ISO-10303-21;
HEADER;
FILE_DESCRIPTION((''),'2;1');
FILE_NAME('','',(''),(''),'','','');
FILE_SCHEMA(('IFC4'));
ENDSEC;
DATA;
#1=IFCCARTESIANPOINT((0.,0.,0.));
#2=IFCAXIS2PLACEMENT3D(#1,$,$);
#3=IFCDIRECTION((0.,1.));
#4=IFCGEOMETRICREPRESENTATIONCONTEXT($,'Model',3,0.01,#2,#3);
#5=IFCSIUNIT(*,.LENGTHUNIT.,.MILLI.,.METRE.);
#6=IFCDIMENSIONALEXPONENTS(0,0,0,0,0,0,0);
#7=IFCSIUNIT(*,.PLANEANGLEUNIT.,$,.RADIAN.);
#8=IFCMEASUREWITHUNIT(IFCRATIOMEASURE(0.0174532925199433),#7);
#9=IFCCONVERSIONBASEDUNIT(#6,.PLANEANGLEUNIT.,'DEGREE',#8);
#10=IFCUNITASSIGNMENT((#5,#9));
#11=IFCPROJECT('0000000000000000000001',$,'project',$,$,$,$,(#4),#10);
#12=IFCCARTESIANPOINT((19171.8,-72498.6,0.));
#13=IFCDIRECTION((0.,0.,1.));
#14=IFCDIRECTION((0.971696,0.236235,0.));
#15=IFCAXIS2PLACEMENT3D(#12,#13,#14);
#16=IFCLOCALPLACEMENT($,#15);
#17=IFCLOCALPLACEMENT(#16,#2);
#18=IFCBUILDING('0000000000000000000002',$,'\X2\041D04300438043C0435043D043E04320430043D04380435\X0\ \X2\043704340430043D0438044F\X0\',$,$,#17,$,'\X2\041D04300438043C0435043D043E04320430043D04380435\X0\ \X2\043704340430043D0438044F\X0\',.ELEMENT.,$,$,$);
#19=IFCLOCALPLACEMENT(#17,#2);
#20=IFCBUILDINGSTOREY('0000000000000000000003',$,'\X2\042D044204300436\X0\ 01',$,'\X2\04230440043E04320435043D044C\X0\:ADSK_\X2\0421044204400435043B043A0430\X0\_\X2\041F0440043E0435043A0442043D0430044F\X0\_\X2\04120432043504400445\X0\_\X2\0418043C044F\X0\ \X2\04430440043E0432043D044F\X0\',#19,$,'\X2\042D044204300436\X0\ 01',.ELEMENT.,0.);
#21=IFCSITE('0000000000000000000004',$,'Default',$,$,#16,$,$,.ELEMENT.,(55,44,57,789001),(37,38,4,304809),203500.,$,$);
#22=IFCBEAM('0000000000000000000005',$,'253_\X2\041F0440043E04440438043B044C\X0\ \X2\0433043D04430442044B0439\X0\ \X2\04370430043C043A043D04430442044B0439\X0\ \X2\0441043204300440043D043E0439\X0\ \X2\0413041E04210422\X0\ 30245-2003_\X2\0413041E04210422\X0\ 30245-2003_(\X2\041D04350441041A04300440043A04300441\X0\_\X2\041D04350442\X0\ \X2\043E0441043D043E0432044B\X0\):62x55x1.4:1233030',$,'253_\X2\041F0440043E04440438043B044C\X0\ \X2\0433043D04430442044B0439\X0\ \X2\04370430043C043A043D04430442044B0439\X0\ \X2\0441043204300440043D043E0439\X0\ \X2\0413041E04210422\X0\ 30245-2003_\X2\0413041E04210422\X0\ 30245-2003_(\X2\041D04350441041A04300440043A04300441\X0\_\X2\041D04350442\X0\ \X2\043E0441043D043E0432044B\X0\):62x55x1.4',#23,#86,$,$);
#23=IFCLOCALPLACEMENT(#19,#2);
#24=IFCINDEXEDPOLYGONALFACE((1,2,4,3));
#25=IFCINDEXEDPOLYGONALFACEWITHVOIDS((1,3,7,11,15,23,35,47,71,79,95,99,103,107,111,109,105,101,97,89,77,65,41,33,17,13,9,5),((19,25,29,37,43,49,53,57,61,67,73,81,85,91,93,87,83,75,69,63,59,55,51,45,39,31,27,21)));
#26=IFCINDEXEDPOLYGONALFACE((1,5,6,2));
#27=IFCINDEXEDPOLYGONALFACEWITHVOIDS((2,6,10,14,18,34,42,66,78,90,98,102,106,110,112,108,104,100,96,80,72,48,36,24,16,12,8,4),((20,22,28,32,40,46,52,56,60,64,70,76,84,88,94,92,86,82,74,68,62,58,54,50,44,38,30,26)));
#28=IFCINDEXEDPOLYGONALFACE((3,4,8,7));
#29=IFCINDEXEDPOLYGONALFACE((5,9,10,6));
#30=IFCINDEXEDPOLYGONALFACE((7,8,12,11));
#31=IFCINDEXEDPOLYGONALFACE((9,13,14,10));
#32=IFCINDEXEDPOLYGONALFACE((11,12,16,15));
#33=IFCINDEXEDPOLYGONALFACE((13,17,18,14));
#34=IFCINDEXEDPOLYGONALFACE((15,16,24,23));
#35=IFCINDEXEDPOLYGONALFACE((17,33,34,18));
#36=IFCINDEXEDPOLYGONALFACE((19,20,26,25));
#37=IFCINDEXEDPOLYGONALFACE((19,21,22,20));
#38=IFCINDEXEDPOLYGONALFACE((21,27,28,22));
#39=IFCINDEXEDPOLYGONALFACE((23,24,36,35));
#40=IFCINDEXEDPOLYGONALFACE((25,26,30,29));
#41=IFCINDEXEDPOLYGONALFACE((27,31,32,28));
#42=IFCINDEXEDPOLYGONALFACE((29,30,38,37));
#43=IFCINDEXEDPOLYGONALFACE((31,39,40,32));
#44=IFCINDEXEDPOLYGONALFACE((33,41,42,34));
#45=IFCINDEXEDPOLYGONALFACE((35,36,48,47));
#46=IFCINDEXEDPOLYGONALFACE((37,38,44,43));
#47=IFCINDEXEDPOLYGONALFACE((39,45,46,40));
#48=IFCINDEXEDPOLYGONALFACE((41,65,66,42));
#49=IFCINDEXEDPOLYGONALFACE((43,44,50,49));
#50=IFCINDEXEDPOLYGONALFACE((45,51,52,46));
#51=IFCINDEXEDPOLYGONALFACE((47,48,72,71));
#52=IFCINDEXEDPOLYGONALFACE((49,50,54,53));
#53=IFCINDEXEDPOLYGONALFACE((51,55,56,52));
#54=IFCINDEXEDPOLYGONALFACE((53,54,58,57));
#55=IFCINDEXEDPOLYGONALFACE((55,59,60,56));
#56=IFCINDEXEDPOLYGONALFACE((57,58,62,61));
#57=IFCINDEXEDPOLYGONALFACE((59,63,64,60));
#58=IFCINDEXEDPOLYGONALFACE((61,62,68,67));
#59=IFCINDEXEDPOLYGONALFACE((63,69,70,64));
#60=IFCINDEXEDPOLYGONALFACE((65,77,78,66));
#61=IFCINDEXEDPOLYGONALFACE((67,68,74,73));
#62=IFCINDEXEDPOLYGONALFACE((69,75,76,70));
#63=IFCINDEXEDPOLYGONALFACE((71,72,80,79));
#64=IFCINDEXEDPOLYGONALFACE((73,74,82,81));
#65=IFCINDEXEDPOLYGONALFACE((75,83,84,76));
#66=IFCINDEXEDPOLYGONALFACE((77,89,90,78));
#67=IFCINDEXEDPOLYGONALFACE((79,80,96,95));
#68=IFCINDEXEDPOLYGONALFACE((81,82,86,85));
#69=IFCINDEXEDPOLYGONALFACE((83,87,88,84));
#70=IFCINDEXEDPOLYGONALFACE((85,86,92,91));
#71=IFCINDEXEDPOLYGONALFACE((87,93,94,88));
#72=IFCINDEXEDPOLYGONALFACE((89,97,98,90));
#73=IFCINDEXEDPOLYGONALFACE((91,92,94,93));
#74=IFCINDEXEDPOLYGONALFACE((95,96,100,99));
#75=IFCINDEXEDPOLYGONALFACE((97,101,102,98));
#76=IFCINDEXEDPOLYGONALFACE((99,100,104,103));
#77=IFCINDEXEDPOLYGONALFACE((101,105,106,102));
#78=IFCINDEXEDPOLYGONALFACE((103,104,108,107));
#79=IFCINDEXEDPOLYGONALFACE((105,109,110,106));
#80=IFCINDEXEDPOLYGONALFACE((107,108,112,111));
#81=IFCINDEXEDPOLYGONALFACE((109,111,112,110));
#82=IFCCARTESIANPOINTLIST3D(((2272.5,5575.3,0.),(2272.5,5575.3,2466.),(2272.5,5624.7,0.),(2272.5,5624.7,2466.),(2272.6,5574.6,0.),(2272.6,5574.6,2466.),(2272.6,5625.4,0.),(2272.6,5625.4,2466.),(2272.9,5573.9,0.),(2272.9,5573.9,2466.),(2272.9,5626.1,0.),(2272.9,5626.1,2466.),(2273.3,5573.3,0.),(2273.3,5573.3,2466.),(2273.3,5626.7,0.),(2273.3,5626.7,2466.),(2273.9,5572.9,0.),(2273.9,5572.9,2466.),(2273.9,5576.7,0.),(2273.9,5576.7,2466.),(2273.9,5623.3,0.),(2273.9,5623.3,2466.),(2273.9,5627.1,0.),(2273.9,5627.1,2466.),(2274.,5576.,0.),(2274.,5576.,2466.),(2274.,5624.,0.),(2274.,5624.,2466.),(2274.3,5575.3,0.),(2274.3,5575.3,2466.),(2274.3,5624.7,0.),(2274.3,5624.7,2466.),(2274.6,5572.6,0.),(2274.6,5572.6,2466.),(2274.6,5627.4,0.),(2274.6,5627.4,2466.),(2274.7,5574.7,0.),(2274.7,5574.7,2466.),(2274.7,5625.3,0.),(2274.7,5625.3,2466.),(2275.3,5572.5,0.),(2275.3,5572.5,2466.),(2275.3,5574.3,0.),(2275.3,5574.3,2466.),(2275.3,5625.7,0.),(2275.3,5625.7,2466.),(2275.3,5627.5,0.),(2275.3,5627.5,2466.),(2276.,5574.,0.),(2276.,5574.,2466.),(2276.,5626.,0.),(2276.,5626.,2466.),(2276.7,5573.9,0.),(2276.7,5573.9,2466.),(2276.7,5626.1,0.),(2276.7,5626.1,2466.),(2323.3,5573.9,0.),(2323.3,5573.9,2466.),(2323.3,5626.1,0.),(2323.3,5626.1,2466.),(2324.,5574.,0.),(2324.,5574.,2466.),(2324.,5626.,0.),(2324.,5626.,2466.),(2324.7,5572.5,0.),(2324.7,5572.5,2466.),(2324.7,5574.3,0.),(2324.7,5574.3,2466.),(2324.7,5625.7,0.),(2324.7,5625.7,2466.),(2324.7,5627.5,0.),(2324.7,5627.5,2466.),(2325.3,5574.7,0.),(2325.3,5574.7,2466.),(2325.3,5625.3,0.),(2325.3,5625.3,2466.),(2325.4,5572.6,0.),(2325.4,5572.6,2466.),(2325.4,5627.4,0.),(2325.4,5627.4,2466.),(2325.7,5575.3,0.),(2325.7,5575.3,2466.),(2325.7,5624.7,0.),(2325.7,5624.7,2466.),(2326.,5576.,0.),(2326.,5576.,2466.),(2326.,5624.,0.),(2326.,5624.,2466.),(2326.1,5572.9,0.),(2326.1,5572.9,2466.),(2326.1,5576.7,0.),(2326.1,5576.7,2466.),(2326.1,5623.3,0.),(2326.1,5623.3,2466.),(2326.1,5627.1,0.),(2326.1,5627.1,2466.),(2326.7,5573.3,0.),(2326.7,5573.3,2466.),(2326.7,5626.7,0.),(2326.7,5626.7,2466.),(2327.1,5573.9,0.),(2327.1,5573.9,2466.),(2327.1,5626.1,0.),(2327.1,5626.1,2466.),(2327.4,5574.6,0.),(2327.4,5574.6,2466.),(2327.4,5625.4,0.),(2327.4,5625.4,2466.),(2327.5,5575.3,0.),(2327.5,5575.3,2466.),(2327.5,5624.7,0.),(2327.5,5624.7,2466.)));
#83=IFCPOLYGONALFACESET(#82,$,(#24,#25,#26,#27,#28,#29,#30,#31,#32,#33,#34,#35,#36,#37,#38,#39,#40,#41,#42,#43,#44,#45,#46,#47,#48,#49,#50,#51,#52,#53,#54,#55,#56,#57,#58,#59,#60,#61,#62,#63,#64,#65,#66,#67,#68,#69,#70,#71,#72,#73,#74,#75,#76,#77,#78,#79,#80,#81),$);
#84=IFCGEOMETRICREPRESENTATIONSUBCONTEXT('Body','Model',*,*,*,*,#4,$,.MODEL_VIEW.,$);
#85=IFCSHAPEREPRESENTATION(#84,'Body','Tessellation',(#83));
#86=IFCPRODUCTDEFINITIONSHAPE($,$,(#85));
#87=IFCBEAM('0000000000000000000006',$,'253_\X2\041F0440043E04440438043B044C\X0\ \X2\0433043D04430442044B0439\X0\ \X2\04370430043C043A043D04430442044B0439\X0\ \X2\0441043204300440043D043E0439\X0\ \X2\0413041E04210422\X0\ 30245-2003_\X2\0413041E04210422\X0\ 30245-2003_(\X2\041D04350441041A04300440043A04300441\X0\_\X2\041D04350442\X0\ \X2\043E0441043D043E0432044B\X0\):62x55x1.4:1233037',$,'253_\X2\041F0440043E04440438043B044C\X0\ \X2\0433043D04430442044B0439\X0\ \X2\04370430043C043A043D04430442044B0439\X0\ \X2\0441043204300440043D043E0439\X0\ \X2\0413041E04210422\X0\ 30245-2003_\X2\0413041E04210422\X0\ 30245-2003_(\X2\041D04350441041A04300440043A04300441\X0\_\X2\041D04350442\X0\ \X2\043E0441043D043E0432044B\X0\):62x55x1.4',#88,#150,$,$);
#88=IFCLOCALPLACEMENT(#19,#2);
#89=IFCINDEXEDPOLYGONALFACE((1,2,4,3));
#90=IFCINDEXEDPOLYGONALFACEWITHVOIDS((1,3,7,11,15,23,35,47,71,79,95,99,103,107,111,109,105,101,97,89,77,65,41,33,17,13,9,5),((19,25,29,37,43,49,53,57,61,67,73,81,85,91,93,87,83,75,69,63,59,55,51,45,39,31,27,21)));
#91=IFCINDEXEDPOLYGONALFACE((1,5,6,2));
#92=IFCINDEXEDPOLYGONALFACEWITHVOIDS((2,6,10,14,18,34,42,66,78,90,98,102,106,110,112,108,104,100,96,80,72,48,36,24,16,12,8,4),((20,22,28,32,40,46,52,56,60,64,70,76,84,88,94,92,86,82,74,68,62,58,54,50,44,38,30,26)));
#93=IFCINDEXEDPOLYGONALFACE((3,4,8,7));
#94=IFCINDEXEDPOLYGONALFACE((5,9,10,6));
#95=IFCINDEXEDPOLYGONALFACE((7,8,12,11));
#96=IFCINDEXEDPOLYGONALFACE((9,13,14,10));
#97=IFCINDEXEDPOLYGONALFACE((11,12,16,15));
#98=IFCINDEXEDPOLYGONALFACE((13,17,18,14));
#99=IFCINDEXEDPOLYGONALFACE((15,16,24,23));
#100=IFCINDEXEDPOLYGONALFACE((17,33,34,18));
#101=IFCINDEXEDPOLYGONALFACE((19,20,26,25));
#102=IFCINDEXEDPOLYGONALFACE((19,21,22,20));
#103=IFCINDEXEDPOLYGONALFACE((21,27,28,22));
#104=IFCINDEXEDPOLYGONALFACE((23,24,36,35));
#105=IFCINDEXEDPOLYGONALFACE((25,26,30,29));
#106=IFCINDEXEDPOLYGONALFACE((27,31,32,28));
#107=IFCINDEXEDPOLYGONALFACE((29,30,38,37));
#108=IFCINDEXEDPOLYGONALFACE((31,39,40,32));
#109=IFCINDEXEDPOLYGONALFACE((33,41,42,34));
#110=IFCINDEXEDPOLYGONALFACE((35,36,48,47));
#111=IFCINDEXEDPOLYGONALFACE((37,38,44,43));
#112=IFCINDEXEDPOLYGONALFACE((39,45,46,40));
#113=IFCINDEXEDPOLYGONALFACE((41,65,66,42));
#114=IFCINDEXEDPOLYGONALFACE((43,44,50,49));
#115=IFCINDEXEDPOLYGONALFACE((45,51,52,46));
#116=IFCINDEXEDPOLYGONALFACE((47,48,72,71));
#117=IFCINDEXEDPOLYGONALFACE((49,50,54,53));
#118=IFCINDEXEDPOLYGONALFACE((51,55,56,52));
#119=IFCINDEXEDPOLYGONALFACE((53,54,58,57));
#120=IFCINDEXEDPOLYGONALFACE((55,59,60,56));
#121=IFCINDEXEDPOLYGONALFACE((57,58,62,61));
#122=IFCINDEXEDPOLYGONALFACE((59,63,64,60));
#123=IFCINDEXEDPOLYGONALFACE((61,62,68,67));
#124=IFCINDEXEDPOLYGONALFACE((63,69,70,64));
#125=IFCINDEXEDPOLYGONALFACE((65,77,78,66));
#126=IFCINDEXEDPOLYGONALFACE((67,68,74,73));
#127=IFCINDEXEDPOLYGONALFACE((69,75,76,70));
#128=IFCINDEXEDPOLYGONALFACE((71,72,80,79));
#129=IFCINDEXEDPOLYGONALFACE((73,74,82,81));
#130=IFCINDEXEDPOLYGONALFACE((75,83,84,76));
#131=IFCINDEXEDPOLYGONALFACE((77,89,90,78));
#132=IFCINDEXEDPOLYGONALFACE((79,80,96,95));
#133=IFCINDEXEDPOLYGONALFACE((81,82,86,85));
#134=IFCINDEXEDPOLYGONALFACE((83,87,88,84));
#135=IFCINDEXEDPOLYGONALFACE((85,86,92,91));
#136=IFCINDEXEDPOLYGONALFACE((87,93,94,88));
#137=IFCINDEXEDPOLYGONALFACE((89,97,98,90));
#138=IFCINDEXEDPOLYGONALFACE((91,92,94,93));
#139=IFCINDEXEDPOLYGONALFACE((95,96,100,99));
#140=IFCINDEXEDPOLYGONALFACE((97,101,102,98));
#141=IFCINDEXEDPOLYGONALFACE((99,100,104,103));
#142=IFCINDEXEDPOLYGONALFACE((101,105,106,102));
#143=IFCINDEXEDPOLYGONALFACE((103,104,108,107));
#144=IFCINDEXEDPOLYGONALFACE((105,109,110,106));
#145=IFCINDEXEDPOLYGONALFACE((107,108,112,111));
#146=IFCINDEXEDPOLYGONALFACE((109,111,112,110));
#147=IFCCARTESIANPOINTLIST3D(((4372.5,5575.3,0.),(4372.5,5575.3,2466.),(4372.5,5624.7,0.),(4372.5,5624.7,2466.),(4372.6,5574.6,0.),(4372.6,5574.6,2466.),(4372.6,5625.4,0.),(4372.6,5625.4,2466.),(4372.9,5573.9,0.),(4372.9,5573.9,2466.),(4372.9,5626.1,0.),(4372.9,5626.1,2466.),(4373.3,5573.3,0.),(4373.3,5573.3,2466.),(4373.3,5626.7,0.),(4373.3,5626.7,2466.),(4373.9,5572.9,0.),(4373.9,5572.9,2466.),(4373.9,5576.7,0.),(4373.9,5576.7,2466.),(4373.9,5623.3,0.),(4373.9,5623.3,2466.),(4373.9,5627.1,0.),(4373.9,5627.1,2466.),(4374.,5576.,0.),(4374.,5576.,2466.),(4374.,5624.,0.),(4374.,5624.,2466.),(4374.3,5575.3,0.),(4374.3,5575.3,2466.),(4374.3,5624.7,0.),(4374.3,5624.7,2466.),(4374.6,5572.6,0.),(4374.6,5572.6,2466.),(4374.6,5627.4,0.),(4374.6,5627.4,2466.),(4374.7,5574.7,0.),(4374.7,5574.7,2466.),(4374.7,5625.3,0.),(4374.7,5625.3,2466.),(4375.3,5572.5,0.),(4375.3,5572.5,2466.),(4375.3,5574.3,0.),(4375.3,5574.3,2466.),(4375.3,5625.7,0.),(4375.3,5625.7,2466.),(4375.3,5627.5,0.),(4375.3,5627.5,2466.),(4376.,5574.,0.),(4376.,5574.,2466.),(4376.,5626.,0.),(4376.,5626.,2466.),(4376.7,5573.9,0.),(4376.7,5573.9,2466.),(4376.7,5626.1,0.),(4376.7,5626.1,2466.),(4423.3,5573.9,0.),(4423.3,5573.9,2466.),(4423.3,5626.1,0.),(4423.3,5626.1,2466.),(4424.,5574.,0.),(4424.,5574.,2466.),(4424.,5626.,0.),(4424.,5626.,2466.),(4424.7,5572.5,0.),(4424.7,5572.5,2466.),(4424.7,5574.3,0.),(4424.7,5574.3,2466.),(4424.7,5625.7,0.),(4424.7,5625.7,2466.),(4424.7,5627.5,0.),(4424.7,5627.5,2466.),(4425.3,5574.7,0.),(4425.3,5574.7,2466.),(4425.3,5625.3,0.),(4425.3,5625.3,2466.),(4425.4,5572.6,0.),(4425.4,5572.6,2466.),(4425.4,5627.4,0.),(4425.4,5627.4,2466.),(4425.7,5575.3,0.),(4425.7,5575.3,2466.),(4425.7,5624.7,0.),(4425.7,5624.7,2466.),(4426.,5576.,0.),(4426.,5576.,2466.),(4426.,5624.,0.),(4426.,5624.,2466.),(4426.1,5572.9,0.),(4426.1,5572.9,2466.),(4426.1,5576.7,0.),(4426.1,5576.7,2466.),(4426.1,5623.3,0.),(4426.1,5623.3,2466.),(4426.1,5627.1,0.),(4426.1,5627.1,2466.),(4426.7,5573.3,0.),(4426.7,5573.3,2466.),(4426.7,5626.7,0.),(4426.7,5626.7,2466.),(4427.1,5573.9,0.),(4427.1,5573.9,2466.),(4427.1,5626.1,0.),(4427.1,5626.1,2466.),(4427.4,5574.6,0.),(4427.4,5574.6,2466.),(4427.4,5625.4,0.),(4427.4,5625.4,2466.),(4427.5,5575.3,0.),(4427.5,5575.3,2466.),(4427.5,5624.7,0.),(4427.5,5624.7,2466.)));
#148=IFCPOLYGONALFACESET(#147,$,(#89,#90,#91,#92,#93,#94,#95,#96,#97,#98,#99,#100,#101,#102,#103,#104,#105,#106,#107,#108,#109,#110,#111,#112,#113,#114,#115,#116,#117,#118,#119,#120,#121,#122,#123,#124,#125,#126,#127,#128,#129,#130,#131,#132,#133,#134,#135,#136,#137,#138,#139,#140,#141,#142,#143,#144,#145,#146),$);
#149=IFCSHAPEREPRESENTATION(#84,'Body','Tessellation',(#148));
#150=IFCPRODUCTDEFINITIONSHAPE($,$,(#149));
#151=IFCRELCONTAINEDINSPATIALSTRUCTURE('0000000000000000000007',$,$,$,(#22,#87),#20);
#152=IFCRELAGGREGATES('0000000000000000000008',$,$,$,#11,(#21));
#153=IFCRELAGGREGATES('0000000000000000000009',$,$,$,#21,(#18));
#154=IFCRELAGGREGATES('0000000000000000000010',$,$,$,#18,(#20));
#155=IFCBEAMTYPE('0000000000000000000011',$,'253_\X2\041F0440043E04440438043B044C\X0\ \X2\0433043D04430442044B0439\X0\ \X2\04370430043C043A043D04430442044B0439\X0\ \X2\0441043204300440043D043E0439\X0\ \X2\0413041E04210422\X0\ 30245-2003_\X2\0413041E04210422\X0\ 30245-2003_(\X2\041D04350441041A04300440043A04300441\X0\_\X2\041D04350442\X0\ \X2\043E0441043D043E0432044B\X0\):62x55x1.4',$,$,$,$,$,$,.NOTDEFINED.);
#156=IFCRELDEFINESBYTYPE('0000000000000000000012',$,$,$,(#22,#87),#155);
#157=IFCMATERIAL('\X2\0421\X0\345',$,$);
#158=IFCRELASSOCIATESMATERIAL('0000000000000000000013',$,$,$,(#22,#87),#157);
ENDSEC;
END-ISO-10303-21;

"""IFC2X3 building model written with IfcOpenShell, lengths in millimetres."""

from ifc_helpers import new_model, entity, si_unit, converted_unit, direction, frame, frame_2d, origin, place, context, subcontext, project, spatial, polyline, circle_curve, parameter, trimmed, segment, composite_curve, outline, extrude, material, type_object, element, save


model = new_model("IFC2X3")

# Units and contexts
model_context = context("Model", 3, precision=0.01, world=origin(), true_north=direction((0.0, 1.0)))
body_context = subcontext(model_context, "Body", "Model", "MODEL_VIEW")
ifc_project = project(units=[si_unit("LENGTHUNIT", "METRE", prefix="MILLI"), converted_unit("PLANEANGLEUNIT", "DEGREE", entity("IfcRatioMeasure", 0.0174532925199433), si_unit("PLANEANGLEUNIT", "RADIAN"), dimensions=[0, 0, 0, 0, 0, 0, 0])], contexts=[model_context])

# Site, building, storey
site_placement = place(None, frame((19171.8, -72498.6, 0.0), z_axis=(0.0, 0.0, 1.0), x_axis=(0.971696, 0.236235, 0.0)))
site = spatial("IfcSite", under=ifc_project, at=site_placement, Name="Default", CompositionType="ELEMENT", RefLatitude=(55, 44, 57, 789001), RefLongitude=(37, 38, 4, 304809), RefElevation=203500.0)
building_placement = place(site_placement, origin())
building = spatial("IfcBuilding", under=site, at=building_placement, Name="Наименование здания", LongName="Наименование здания", CompositionType="ELEMENT")
storey_placement = place(building_placement, origin())
storey = spatial("IfcBuildingStorey", under=building, at=storey_placement, Name="Этаж 01", ObjectType="Уровень:ADSK_Стрелка_Проектная_Вверх_Имя уровня", LongName="Этаж 01", CompositionType="ELEMENT", Elevation=0.0)

# Beams
ifc_material_1 = material(Name="С345")
beam_type_1 = type_object("IfcBeamType", Name="253_Профиль гнутый замкнутый сварной ГОСТ 30245-2003_ГОСТ 30245-2003_(НесКаркас_Нет основы):62x55x1.4", PredefinedType="NOTDEFINED")
beam_1_placement = place(storey_placement, frame((2270.9, 5570.9, 0.0), z_axis=(1.0, 0.0, 0.0), x_axis=(0.0, 0.0, -1.0)))
element("IfcBeam", 1, at=beam_1_placement, inside=storey, type_object=beam_type_1, material=ifc_material_1, Name="253_Профиль гнутый замкнутый сварной ГОСТ 30245-2003_ГОСТ 30245-2003_(НесКаркас_Нет основы):62x55x1.4:1233030", ObjectType="253_Профиль гнутый замкнутый сварной ГОСТ 30245-2003_ГОСТ 30245-2003_(НесКаркас_Нет основы):62x55x1.4", context=body_context, shape_type="SweptSolid", body=[
    extrude(outline(composite_curve([segment(trimmed(circle_curve(frame_2d((24.7, -24.7), x_axis=(1.0, 0.0)), 2.8), [parameter(270.0)], [parameter(0.0)], True, "PARAMETER"), True, "CONTINUOUS"), segment(polyline([(27.5, -24.7), (27.5, 24.7)]), True, "CONTINUOUS"), segment(trimmed(circle_curve(frame_2d((24.7, 24.7), x_axis=(1.0, 0.0)), 2.8), [parameter(0.0)], [parameter(90.0)], True, "PARAMETER"), True, "CONTINUOUS"), segment(polyline([(24.7, 27.5), (-24.7, 27.5)]), True, "CONTINUOUS"), segment(trimmed(circle_curve(frame_2d((-24.7, 24.7), x_axis=(1.0, 0.0)), 2.8), [parameter(90.0)], [parameter(180.0)], True, "PARAMETER"), True, "CONTINUOUS"), segment(polyline([(-27.5, 24.7), (-27.5, -24.7)]), True, "CONTINUOUS"), segment(trimmed(circle_curve(frame_2d((-24.7, -24.7), x_axis=(1.0, 0.0)), 2.8), [parameter(180.0)], [parameter(270.0)], True, "PARAMETER"), True, "CONTINUOUS"), segment(polyline([(-24.7, -27.5), (24.7, -27.5)]), True, "CONTINUOUS")], self_intersect=False), holes=[composite_curve([segment(polyline([(23.3, -26.1), (-23.3, -26.1)]), True, "CONTINUOUS"), segment(trimmed(circle_curve(frame_2d((-23.3, -23.3), x_axis=(1.0, 0.0)), 2.8), [parameter(180.0)], [parameter(270.0)], True, "PARAMETER"), False, "CONTINUOUS"), segment(polyline([(-26.1, -23.3), (-26.1, 23.3)]), True, "CONTINUOUS"), segment(trimmed(circle_curve(frame_2d((-23.3, 23.3), x_axis=(1.0, 0.0)), 2.8), [parameter(90.0)], [parameter(180.0)], True, "PARAMETER"), False, "CONTINUOUS"), segment(polyline([(-23.3, 26.1), (23.3, 26.1)]), True, "CONTINUOUS"), segment(trimmed(circle_curve(frame_2d((23.3, 23.3), x_axis=(1.0, 0.0)), 2.8), [parameter(0.0)], [parameter(90.0)], True, "PARAMETER"), False, "CONTINUOUS"), segment(polyline([(26.1, 23.3), (26.1, -23.3)]), True, "CONTINUOUS"), segment(trimmed(circle_curve(frame_2d((23.3, -23.3), x_axis=(1.0, 0.0)), 2.8), [parameter(270.0)], [parameter(0.0)], True, "PARAMETER"), False, "CONTINUOUS")], self_intersect=False)]), frame((-2466.0, 29.1, 29.1), z_axis=(1.0, 0.0, 0.0), x_axis=(0.0, 1.0, 0.0)), (0.0, 0.0, 1.0), 2466.0),
])
beam_2_placement = place(storey_placement, frame((4370.9, 5570.9, 0.0), z_axis=(1.0, 0.0, 0.0), x_axis=(0.0, 0.0, -1.0)))
element("IfcBeam", 2, at=beam_2_placement, inside=storey, type_object=beam_type_1, material=ifc_material_1, Name="253_Профиль гнутый замкнутый сварной ГОСТ 30245-2003_ГОСТ 30245-2003_(НесКаркас_Нет основы):62x55x1.4:1233037", ObjectType="253_Профиль гнутый замкнутый сварной ГОСТ 30245-2003_ГОСТ 30245-2003_(НесКаркас_Нет основы):62x55x1.4", context=body_context, shape_type="SweptSolid", body=[
    extrude(outline(composite_curve([segment(trimmed(circle_curve(frame_2d((24.7, -24.7), x_axis=(1.0, 0.0)), 2.8), [parameter(270.0)], [parameter(0.0)], True, "PARAMETER"), True, "CONTINUOUS"), segment(polyline([(27.5, -24.7), (27.5, 24.7)]), True, "CONTINUOUS"), segment(trimmed(circle_curve(frame_2d((24.7, 24.7), x_axis=(1.0, 0.0)), 2.8), [parameter(0.0)], [parameter(90.0)], True, "PARAMETER"), True, "CONTINUOUS"), segment(polyline([(24.7, 27.5), (-24.7, 27.5)]), True, "CONTINUOUS"), segment(trimmed(circle_curve(frame_2d((-24.7, 24.7), x_axis=(1.0, 0.0)), 2.8), [parameter(90.0)], [parameter(180.0)], True, "PARAMETER"), True, "CONTINUOUS"), segment(polyline([(-27.5, 24.7), (-27.5, -24.7)]), True, "CONTINUOUS"), segment(trimmed(circle_curve(frame_2d((-24.7, -24.7), x_axis=(1.0, 0.0)), 2.8), [parameter(180.0)], [parameter(270.0)], True, "PARAMETER"), True, "CONTINUOUS"), segment(polyline([(-24.7, -27.5), (24.7, -27.5)]), True, "CONTINUOUS")], self_intersect=False), holes=[composite_curve([segment(polyline([(23.3, -26.1), (-23.3, -26.1)]), True, "CONTINUOUS"), segment(trimmed(circle_curve(frame_2d((-23.3, -23.3), x_axis=(1.0, 0.0)), 2.8), [parameter(180.0)], [parameter(270.0)], True, "PARAMETER"), False, "CONTINUOUS"), segment(polyline([(-26.1, -23.3), (-26.1, 23.3)]), True, "CONTINUOUS"), segment(trimmed(circle_curve(frame_2d((-23.3, 23.3), x_axis=(1.0, 0.0)), 2.8), [parameter(90.0)], [parameter(180.0)], True, "PARAMETER"), False, "CONTINUOUS"), segment(polyline([(-23.3, 26.1), (23.3, 26.1)]), True, "CONTINUOUS"), segment(trimmed(circle_curve(frame_2d((23.3, 23.3), x_axis=(1.0, 0.0)), 2.8), [parameter(0.0)], [parameter(90.0)], True, "PARAMETER"), False, "CONTINUOUS"), segment(polyline([(26.1, 23.3), (26.1, -23.3)]), True, "CONTINUOUS"), segment(trimmed(circle_curve(frame_2d((23.3, -23.3), x_axis=(1.0, 0.0)), 2.8), [parameter(270.0)], [parameter(0.0)], True, "PARAMETER"), False, "CONTINUOUS")], self_intersect=False)]), frame((-2466.0, 29.1, 29.1), z_axis=(1.0, 0.0, 0.0), x_axis=(0.0, 1.0, 0.0)), (0.0, 0.0, 1.0), 2466.0),
])

save(model, "model.ifc")
